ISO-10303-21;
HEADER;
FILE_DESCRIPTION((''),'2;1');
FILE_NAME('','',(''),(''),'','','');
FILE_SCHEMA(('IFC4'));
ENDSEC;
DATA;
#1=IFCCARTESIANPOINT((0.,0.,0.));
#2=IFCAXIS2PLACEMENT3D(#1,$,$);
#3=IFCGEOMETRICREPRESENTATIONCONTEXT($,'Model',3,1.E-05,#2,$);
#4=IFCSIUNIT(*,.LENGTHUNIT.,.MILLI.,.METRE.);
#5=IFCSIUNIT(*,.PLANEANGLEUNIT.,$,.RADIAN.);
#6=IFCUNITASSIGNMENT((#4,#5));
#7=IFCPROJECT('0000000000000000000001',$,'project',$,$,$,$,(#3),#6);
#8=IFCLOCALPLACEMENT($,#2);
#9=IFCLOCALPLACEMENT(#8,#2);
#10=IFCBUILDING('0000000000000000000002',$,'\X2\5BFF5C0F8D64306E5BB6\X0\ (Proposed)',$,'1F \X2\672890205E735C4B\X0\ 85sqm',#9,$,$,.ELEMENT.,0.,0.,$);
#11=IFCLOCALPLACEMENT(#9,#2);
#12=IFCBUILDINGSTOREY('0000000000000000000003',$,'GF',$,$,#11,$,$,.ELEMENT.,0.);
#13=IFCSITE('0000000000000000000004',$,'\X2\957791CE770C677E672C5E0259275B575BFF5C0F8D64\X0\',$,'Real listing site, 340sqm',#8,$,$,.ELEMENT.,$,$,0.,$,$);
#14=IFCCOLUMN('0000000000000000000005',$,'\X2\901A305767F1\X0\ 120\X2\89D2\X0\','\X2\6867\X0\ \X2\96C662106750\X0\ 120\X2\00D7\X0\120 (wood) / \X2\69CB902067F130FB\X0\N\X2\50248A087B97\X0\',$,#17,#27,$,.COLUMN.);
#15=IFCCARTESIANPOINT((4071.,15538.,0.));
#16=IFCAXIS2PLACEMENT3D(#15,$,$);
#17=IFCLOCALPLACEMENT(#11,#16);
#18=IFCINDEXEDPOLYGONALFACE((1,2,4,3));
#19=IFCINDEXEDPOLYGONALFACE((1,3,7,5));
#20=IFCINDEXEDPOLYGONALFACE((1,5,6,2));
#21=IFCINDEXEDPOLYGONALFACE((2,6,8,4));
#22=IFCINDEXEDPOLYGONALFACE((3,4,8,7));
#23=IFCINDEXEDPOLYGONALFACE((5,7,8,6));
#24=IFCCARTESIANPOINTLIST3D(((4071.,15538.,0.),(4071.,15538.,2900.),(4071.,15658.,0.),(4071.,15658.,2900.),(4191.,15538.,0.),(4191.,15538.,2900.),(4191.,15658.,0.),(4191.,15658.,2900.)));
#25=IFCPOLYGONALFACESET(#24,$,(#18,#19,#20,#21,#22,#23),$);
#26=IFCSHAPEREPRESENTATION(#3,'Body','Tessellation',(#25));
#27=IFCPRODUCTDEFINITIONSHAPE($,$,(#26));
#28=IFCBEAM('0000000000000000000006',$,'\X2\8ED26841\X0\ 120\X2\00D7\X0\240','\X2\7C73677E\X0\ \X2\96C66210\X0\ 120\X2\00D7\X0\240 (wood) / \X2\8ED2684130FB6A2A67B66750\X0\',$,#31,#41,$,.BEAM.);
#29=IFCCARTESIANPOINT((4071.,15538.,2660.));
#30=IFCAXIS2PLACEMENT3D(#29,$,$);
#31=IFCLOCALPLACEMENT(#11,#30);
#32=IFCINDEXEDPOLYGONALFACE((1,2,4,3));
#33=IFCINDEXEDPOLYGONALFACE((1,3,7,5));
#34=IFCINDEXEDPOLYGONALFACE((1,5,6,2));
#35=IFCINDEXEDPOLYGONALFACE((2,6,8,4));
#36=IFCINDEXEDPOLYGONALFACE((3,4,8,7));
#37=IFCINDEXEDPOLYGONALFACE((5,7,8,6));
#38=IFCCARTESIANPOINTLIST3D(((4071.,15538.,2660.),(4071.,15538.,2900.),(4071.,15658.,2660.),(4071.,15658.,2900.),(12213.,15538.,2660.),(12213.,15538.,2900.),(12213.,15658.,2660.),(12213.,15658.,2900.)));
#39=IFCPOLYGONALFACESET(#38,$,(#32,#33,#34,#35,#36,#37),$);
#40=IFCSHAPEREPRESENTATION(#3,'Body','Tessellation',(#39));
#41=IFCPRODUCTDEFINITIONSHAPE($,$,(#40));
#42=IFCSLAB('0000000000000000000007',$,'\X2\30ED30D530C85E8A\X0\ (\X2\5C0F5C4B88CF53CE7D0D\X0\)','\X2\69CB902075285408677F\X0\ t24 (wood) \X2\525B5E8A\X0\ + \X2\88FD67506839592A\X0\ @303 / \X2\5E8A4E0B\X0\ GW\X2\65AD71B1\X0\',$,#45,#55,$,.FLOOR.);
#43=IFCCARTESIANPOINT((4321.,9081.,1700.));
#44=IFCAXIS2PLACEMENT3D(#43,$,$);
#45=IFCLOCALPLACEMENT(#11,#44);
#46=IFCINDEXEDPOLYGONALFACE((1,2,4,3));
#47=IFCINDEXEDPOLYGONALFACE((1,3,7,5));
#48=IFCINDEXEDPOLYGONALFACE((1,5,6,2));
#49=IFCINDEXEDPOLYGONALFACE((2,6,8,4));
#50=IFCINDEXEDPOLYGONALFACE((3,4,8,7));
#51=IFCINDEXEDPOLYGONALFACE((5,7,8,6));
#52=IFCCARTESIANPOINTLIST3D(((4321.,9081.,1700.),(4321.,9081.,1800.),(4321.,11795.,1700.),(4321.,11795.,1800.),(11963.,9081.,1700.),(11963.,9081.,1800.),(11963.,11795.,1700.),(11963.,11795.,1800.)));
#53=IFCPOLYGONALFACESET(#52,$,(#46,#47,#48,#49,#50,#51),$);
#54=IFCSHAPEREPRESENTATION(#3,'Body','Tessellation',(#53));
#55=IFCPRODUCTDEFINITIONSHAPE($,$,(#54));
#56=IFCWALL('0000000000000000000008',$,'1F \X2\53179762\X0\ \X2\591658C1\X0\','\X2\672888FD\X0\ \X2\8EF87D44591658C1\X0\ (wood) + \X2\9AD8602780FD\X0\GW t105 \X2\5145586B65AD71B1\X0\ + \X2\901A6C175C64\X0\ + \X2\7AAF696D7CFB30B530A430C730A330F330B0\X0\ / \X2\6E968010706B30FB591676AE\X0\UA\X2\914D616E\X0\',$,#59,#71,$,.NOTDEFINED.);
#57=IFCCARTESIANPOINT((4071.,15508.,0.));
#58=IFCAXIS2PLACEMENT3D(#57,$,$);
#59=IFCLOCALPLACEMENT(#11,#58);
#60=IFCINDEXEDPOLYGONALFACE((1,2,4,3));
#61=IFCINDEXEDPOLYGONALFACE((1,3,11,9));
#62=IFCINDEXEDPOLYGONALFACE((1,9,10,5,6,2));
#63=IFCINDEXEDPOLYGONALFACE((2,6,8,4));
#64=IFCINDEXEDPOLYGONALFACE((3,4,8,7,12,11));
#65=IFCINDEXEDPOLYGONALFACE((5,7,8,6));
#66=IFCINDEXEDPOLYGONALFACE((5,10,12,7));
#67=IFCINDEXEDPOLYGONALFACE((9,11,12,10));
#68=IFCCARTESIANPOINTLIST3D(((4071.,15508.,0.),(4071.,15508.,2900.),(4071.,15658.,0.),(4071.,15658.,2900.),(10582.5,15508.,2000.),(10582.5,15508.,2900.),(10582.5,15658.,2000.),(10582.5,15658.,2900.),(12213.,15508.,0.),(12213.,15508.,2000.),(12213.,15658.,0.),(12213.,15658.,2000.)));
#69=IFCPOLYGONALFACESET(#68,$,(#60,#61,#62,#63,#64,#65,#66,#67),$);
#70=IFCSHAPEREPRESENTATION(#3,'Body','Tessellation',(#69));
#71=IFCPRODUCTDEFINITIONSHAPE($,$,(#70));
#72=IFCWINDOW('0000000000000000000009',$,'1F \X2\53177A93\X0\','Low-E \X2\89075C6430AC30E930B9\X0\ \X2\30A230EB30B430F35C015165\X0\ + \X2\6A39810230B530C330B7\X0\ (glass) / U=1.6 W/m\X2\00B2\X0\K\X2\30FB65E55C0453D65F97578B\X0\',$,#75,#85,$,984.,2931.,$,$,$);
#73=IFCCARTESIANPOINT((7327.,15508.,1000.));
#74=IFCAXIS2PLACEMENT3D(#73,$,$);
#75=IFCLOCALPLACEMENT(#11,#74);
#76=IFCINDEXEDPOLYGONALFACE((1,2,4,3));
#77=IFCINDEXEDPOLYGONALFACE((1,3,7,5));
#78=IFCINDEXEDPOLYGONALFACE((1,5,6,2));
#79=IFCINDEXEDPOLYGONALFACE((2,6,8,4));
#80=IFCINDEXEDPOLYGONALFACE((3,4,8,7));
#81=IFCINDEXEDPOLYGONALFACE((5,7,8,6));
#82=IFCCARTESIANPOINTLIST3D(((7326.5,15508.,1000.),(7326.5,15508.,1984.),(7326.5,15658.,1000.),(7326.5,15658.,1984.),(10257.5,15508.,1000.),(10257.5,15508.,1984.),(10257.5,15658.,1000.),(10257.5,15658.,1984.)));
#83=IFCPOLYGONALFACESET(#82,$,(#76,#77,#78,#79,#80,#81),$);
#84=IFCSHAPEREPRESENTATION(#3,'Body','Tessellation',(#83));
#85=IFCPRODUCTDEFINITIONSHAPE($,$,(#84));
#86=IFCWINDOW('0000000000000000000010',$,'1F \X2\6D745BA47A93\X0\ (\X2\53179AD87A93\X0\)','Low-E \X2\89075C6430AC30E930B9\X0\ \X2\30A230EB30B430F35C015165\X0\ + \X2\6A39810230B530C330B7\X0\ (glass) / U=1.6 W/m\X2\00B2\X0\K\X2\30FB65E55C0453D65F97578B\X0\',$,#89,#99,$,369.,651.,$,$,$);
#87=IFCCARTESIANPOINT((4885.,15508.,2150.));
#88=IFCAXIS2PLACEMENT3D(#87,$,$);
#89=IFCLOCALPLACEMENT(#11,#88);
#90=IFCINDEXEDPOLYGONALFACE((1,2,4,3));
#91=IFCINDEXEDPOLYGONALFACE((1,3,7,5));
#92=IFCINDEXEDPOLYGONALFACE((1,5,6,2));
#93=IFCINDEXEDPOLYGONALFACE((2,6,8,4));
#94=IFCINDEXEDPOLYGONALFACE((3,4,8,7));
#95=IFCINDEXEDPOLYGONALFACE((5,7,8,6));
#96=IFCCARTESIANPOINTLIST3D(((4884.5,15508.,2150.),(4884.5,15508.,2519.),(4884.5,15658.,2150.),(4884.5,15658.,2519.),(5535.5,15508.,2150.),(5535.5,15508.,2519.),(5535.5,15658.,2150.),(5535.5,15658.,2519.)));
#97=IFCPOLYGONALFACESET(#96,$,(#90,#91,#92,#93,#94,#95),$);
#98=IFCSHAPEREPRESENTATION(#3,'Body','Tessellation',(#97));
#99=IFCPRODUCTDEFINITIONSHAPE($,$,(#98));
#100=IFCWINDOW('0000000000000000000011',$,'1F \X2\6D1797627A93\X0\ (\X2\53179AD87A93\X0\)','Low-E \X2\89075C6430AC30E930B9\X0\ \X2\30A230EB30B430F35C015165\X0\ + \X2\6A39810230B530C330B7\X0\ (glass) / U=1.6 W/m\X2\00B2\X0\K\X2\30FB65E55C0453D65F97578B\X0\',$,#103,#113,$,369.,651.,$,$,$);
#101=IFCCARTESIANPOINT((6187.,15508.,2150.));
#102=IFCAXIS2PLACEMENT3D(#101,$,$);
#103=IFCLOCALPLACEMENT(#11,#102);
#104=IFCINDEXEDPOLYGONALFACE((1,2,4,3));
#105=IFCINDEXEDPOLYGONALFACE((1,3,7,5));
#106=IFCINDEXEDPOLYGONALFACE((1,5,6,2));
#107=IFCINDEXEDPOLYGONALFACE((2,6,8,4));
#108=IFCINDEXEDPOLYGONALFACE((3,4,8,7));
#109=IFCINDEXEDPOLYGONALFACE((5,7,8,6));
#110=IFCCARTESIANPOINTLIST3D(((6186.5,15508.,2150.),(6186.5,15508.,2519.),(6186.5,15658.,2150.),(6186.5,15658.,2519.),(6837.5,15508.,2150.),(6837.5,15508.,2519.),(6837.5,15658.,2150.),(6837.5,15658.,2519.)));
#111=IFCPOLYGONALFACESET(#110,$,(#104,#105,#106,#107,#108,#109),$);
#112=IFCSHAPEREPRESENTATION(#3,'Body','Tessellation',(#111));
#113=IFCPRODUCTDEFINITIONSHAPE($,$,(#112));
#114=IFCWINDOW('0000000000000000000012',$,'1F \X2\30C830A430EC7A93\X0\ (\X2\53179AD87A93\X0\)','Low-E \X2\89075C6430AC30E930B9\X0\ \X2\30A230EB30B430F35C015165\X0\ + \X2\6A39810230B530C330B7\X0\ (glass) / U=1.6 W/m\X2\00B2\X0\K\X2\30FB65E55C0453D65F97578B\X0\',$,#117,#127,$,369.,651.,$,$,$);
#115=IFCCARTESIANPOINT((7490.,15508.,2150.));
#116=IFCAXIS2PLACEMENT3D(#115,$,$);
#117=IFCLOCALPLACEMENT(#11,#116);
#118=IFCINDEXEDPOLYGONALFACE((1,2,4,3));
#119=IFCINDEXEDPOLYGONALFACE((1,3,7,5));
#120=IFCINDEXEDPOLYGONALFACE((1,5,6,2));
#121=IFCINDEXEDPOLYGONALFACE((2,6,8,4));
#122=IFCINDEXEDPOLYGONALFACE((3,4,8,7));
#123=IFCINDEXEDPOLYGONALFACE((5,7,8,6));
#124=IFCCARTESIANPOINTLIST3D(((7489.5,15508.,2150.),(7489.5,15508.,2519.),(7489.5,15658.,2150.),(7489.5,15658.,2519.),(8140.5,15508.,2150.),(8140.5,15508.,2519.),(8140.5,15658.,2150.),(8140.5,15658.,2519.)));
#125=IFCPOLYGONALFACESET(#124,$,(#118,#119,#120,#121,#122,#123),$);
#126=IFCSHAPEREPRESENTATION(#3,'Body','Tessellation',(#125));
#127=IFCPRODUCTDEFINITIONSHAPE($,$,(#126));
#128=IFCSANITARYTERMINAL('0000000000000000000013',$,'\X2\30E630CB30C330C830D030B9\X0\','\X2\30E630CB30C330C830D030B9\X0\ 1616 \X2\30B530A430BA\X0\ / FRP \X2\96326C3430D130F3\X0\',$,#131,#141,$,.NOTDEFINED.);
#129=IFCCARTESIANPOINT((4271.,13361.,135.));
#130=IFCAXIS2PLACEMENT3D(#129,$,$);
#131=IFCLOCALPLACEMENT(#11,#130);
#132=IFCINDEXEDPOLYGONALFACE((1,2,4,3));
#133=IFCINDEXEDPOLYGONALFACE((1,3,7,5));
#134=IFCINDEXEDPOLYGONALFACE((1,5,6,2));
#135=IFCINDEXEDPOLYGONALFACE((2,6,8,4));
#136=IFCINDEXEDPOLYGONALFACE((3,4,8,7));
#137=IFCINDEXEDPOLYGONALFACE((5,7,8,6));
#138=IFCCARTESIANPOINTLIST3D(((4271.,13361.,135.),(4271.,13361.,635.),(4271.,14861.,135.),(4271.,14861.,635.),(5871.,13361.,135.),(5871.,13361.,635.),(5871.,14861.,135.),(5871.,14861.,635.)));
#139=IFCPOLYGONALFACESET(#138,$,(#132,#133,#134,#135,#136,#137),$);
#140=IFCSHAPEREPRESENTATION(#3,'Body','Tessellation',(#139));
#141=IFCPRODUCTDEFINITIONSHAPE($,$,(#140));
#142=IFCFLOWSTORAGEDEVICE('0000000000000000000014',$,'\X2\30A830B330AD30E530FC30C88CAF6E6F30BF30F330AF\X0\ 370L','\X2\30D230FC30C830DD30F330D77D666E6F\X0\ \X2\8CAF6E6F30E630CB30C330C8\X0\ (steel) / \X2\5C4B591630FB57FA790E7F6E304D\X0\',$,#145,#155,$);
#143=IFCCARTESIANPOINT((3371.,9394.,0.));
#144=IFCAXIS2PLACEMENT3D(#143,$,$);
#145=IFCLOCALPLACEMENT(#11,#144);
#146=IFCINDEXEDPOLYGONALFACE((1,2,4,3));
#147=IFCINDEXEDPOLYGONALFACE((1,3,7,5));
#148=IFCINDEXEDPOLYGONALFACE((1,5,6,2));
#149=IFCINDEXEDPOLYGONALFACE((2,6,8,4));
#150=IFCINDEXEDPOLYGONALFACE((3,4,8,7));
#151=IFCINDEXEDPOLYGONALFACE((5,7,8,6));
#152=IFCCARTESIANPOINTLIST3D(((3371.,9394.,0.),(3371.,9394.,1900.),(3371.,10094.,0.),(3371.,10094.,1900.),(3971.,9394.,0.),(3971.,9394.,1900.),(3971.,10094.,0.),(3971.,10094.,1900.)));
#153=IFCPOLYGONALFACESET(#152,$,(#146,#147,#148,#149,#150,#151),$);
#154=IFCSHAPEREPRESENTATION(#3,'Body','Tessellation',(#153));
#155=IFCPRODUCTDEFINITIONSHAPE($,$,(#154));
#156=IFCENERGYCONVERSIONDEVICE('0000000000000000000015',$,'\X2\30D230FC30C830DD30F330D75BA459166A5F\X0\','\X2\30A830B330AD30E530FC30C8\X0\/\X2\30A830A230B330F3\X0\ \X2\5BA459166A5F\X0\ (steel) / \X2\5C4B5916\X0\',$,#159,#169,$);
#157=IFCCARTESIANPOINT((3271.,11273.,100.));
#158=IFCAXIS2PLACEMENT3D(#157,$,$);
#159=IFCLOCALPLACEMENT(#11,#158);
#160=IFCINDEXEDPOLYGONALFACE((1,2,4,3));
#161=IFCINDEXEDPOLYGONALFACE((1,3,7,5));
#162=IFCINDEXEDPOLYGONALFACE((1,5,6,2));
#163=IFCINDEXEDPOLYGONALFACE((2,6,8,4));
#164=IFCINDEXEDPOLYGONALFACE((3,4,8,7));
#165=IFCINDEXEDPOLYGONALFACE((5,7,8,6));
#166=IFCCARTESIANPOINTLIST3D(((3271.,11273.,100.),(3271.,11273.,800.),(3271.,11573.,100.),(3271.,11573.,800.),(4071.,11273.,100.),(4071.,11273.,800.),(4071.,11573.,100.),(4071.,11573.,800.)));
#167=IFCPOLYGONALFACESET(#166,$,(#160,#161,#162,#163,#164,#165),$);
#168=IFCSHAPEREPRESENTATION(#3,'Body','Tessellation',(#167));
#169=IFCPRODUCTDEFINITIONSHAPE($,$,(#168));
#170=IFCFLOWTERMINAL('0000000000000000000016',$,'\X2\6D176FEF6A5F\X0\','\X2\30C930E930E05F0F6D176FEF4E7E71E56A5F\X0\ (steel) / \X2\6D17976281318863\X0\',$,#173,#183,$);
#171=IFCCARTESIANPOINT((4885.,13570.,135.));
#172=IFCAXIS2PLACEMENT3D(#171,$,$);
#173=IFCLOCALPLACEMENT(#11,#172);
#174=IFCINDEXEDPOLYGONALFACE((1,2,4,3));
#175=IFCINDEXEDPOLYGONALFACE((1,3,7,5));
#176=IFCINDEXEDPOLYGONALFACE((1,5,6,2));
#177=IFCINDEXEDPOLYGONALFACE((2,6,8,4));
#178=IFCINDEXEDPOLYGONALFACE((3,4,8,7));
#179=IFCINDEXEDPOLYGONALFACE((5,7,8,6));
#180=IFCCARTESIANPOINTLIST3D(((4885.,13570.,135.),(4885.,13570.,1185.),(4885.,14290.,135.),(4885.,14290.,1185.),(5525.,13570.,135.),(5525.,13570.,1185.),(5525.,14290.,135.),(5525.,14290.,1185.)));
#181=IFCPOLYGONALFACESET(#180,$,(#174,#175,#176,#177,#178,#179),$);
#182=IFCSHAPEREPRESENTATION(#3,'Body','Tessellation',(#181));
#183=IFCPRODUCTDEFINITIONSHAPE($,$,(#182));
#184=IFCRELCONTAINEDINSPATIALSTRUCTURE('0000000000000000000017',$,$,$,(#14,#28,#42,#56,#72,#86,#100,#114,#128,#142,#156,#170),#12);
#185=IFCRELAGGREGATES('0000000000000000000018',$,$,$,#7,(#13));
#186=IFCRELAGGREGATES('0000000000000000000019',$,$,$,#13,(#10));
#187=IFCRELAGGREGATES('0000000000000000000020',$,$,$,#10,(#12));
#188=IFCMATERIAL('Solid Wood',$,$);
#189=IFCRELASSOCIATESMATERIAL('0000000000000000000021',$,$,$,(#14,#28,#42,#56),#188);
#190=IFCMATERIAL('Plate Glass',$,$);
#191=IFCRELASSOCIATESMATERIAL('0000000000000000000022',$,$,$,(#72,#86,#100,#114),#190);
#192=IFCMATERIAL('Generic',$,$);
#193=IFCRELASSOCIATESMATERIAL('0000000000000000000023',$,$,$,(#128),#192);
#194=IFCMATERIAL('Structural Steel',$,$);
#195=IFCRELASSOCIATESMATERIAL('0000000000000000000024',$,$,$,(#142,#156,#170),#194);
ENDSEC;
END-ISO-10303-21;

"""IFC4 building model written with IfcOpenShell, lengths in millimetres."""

from ifc_helpers import new_model, si_unit, frame, frame_2d, origin, place, context, project, spatial, rectangle, extrude, material, element, fill, save


model = new_model("IFC4")

# Units and contexts
model_context = context("Model", 3, precision=1e-05, world=origin())
ifc_project = project(units=[si_unit("LENGTHUNIT", "METRE", prefix="MILLI"), si_unit("PLANEANGLEUNIT", "RADIAN")], contexts=[model_context])

# Site, building, storey
site_placement = place(None, origin())
site = spatial("IfcSite", under=ifc_project, at=site_placement, Name="長野県松本市大字寿小赤", ObjectType="Real listing site, 340sqm", CompositionType="ELEMENT", RefElevation=0.0)
building_placement = place(site_placement, origin())
building = spatial("IfcBuilding", under=site, at=building_placement, Name="寿小赤の家 (Proposed)", ObjectType="1F 木造平屋 85sqm", CompositionType="ELEMENT", ElevationOfRefHeight=0.0, ElevationOfTerrain=0.0)
storey_placement = place(building_placement, origin())
storey = spatial("IfcBuildingStorey", under=building, at=storey_placement, Name="GF", CompositionType="ELEMENT", Elevation=0.0)

# Column
ifc_material_1 = material(Name="Solid Wood")
column_1_placement = place(storey_placement, frame((4071.0, 15538.0, 0.0)))
element("IfcColumn", 1, at=column_1_placement, inside=storey, material=ifc_material_1, Name="通し柱 120角", Description="桧 集成材 120×120 (wood) / 構造柱・N値計算", PredefinedType="COLUMN", context=model_context, shape_type="SweptSolid", body=[
    extrude(rectangle(XDim=120.0, YDim=120.0, at=frame_2d((60.0, 60.0))), frame((4071.0, 15538.0, 0.0)), (0.0, 0.0, 1.0), 2900.0),
])

# Beam
beam_1_placement = place(storey_placement, frame((4071.0, 15538.0, 2660.0)))
element("IfcBeam", 2, at=beam_1_placement, inside=storey, material=ifc_material_1, Name="軒桁 120×240", Description="米松 集成 120×240 (wood) / 軒桁・横架材", PredefinedType="BEAM", context=model_context, shape_type="SweptSolid", body=[
    extrude(rectangle(XDim=8142.0, YDim=120.0, at=frame_2d((4071.0, 60.0))), frame((4071.0, 15538.0, 2660.0)), (0.0, 0.0, 1.0), 240.0),
])

# Slab
slab_placement = place(storey_placement, frame((4321.0, 9081.0, 1700.0)))
element("IfcSlab", 3, at=slab_placement, inside=storey, material=ifc_material_1, Name="ロフト床 (小屋裏収納)", Description="構造用合板 t24 (wood) 剛床 + 製材根太 @303 / 床下 GW断熱", PredefinedType="FLOOR", context=model_context, shape_type="SweptSolid", body=[
    extrude(rectangle(XDim=7642.0, YDim=2714.0, at=frame_2d((3821.0, 1357.0))), frame((4321.0, 9081.0, 1700.0)), (0.0, 0.0, 1.0), 100.0),
])

# Wall, openings, windows
wall_1_placement = place(storey_placement, frame((4071.0, 15508.0, 0.0)))
wall_1 = element("IfcWall", 4, at=wall_1_placement, inside=storey, material=ifc_material_1, Name="1F 北面 外壁", Description="木製 軸組外壁 (wood) + 高性能GW t105 充填断熱 + 通気層 + 窯業系サイディング / 準耐火・外皮UA配慮", PredefinedType="NOTDEFINED", context=model_context, shape_type="SweptSolid", body=[
    extrude(rectangle(XDim=8142.0, YDim=150.0, at=frame_2d((4071.0, 75.0))), frame((4071.0, 15508.0, 0.0)), (0.0, 0.0, 1.0), 2900.0),
])
opening_1_placement = place(storey_placement, frame((7327.0, 15508.0, 1000.0)))
opening_1 = element("IfcOpeningElement", 5, at=opening_1_placement, cuts=wall_1, PredefinedType="NOTDEFINED", context=model_context, shape_type="SweptSolid", body=[
    extrude(rectangle(XDim=2931.0, YDim=150.0, at=frame_2d((1465.0, 75.0))), frame((7327.0, 15508.0, 1000.0)), (0.0, 0.0, 1.0), 984.0),
])
opening_2_placement = place(storey_placement, frame((4885.0, 15508.0, 2150.0)))
opening_2 = element("IfcOpeningElement", 6, at=opening_2_placement, cuts=wall_1, PredefinedType="NOTDEFINED", context=model_context, shape_type="SweptSolid", body=[
    extrude(rectangle(XDim=651.0, YDim=150.0, at=frame_2d((325.0, 75.0))), frame((4885.0, 15508.0, 2150.0)), (0.0, 0.0, 1.0), 369.0),
])
opening_3_placement = place(storey_placement, frame((6187.0, 15508.0, 2150.0)))
opening_3 = element("IfcOpeningElement", 7, at=opening_3_placement, cuts=wall_1, PredefinedType="NOTDEFINED", context=model_context, shape_type="SweptSolid", body=[
    extrude(rectangle(XDim=651.0, YDim=150.0, at=frame_2d((325.0, 75.0))), frame((6187.0, 15508.0, 2150.0)), (0.0, 0.0, 1.0), 369.0),
])
opening_4_placement = place(storey_placement, frame((7490.0, 15508.0, 2150.0)))
opening_4 = element("IfcOpeningElement", 8, at=opening_4_placement, cuts=wall_1, PredefinedType="NOTDEFINED", context=model_context, shape_type="SweptSolid", body=[
    extrude(rectangle(XDim=651.0, YDim=150.0, at=frame_2d((325.0, 75.0))), frame((7490.0, 15508.0, 2150.0)), (0.0, 0.0, 1.0), 369.0),
])
ifc_material_2 = material(Name="Plate Glass")
window_1_placement = place(storey_placement, frame((7327.0, 15508.0, 1000.0)))
window_1 = element("IfcWindow", 9, at=window_1_placement, inside=storey, material=ifc_material_2, Name="1F 北窓", Description="Low-E 複層ガラス アルゴン封入 + 樹脂サッシ (glass) / U=1.6 W/m²K・日射取得型", OverallHeight=984.0, OverallWidth=2931.0, context=model_context, shape_type="SweptSolid", body=[
    extrude(rectangle(XDim=2931.0, YDim=150.0, at=frame_2d((1465.0, 75.0))), frame((7327.0, 15508.0, 1000.0)), (0.0, 0.0, 1.0), 984.0),
])
fill(opening_1, window_1)
window_2_placement = place(storey_placement, frame((4885.0, 15508.0, 2150.0)))
window_2 = element("IfcWindow", 10, at=window_2_placement, inside=storey, material=ifc_material_2, Name="1F 浴室窓 (北高窓)", Description="Low-E 複層ガラス アルゴン封入 + 樹脂サッシ (glass) / U=1.6 W/m²K・日射取得型", OverallHeight=369.0, OverallWidth=651.0, context=model_context, shape_type="SweptSolid", body=[
    extrude(rectangle(XDim=651.0, YDim=150.0, at=frame_2d((325.0, 75.0))), frame((4885.0, 15508.0, 2150.0)), (0.0, 0.0, 1.0), 369.0),
])
fill(opening_2, window_2)
window_3_placement = place(storey_placement, frame((6187.0, 15508.0, 2150.0)))
window_3 = element("IfcWindow", 11, at=window_3_placement, inside=storey, material=ifc_material_2, Name="1F 洗面窓 (北高窓)", Description="Low-E 複層ガラス アルゴン封入 + 樹脂サッシ (glass) / U=1.6 W/m²K・日射取得型", OverallHeight=369.0, OverallWidth=651.0, context=model_context, shape_type="SweptSolid", body=[
    extrude(rectangle(XDim=651.0, YDim=150.0, at=frame_2d((325.0, 75.0))), frame((6187.0, 15508.0, 2150.0)), (0.0, 0.0, 1.0), 369.0),
])
fill(opening_3, window_3)
window_4_placement = place(storey_placement, frame((7490.0, 15508.0, 2150.0)))
window_4 = element("IfcWindow", 12, at=window_4_placement, inside=storey, material=ifc_material_2, Name="1F トイレ窓 (北高窓)", Description="Low-E 複層ガラス アルゴン封入 + 樹脂サッシ (glass) / U=1.6 W/m²K・日射取得型", OverallHeight=369.0, OverallWidth=651.0, context=model_context, shape_type="SweptSolid", body=[
    extrude(rectangle(XDim=651.0, YDim=150.0, at=frame_2d((325.0, 75.0))), frame((7490.0, 15508.0, 2150.0)), (0.0, 0.0, 1.0), 369.0),
])
fill(opening_4, window_4)

# Sanitary terminal
ifc_material_3 = material(Name="Generic")
sanitary_terminal_placement = place(storey_placement, frame((4271.0, 13361.0, 135.0)))
element("IfcSanitaryTerminal", 13, at=sanitary_terminal_placement, inside=storey, material=ifc_material_3, Name="ユニットバス", Description="ユニットバス 1616 サイズ / FRP 防水パン", PredefinedType="NOTDEFINED", context=model_context, shape_type="SweptSolid", body=[
    extrude(rectangle(XDim=1600.0, YDim=1500.0, at=frame_2d((800.0, 750.0))), frame((4271.0, 13361.0, 135.0)), (0.0, 0.0, 1.0), 500.0),
])

# Flow storage device
ifc_material_4 = material(Name="Structural Steel")
flow_storage_device_placement = place(storey_placement, frame((3371.0, 9394.0, 0.0)))
element("IfcFlowStorageDevice", 14, at=flow_storage_device_placement, inside=storey, material=ifc_material_4, Name="エコキュート貯湯タンク 370L", Description="ヒートポンプ給湯 貯湯ユニット (steel) / 屋外・基礎置き", context=model_context, shape_type="SweptSolid", body=[
    extrude(rectangle(XDim=600.0, YDim=700.0, at=frame_2d((300.0, 350.0))), frame((3371.0, 9394.0, 0.0)), (0.0, 0.0, 1.0), 1900.0),
])

# Energy conversion device
energy_conversion_device_placement = place(storey_placement, frame((3271.0, 11273.0, 100.0)))
element("IfcEnergyConversionDevice", 15, at=energy_conversion_device_placement, inside=storey, material=ifc_material_4, Name="ヒートポンプ室外機", Description="エコキュート/エアコン 室外機 (steel) / 屋外", context=model_context, shape_type="SweptSolid", body=[
    extrude(rectangle(XDim=800.0, YDim=300.0, at=frame_2d((400.0, 150.0))), frame((3271.0, 11273.0, 100.0)), (0.0, 0.0, 1.0), 700.0),
])

# Flow terminal
flow_terminal_placement = place(storey_placement, frame((4885.0, 13570.0, 135.0)))
element("IfcFlowTerminal", 16, at=flow_terminal_placement, inside=storey, material=ifc_material_4, Name="洗濯機", Description="ドラム式洗濯乾燥機 (steel) / 洗面脱衣", context=model_context, shape_type="SweptSolid", body=[
    extrude(rectangle(XDim=640.0, YDim=720.0, at=frame_2d((320.0, 360.0))), frame((4885.0, 13570.0, 135.0)), (0.0, 0.0, 1.0), 1050.0),
])

save(model, "model.ifc")
